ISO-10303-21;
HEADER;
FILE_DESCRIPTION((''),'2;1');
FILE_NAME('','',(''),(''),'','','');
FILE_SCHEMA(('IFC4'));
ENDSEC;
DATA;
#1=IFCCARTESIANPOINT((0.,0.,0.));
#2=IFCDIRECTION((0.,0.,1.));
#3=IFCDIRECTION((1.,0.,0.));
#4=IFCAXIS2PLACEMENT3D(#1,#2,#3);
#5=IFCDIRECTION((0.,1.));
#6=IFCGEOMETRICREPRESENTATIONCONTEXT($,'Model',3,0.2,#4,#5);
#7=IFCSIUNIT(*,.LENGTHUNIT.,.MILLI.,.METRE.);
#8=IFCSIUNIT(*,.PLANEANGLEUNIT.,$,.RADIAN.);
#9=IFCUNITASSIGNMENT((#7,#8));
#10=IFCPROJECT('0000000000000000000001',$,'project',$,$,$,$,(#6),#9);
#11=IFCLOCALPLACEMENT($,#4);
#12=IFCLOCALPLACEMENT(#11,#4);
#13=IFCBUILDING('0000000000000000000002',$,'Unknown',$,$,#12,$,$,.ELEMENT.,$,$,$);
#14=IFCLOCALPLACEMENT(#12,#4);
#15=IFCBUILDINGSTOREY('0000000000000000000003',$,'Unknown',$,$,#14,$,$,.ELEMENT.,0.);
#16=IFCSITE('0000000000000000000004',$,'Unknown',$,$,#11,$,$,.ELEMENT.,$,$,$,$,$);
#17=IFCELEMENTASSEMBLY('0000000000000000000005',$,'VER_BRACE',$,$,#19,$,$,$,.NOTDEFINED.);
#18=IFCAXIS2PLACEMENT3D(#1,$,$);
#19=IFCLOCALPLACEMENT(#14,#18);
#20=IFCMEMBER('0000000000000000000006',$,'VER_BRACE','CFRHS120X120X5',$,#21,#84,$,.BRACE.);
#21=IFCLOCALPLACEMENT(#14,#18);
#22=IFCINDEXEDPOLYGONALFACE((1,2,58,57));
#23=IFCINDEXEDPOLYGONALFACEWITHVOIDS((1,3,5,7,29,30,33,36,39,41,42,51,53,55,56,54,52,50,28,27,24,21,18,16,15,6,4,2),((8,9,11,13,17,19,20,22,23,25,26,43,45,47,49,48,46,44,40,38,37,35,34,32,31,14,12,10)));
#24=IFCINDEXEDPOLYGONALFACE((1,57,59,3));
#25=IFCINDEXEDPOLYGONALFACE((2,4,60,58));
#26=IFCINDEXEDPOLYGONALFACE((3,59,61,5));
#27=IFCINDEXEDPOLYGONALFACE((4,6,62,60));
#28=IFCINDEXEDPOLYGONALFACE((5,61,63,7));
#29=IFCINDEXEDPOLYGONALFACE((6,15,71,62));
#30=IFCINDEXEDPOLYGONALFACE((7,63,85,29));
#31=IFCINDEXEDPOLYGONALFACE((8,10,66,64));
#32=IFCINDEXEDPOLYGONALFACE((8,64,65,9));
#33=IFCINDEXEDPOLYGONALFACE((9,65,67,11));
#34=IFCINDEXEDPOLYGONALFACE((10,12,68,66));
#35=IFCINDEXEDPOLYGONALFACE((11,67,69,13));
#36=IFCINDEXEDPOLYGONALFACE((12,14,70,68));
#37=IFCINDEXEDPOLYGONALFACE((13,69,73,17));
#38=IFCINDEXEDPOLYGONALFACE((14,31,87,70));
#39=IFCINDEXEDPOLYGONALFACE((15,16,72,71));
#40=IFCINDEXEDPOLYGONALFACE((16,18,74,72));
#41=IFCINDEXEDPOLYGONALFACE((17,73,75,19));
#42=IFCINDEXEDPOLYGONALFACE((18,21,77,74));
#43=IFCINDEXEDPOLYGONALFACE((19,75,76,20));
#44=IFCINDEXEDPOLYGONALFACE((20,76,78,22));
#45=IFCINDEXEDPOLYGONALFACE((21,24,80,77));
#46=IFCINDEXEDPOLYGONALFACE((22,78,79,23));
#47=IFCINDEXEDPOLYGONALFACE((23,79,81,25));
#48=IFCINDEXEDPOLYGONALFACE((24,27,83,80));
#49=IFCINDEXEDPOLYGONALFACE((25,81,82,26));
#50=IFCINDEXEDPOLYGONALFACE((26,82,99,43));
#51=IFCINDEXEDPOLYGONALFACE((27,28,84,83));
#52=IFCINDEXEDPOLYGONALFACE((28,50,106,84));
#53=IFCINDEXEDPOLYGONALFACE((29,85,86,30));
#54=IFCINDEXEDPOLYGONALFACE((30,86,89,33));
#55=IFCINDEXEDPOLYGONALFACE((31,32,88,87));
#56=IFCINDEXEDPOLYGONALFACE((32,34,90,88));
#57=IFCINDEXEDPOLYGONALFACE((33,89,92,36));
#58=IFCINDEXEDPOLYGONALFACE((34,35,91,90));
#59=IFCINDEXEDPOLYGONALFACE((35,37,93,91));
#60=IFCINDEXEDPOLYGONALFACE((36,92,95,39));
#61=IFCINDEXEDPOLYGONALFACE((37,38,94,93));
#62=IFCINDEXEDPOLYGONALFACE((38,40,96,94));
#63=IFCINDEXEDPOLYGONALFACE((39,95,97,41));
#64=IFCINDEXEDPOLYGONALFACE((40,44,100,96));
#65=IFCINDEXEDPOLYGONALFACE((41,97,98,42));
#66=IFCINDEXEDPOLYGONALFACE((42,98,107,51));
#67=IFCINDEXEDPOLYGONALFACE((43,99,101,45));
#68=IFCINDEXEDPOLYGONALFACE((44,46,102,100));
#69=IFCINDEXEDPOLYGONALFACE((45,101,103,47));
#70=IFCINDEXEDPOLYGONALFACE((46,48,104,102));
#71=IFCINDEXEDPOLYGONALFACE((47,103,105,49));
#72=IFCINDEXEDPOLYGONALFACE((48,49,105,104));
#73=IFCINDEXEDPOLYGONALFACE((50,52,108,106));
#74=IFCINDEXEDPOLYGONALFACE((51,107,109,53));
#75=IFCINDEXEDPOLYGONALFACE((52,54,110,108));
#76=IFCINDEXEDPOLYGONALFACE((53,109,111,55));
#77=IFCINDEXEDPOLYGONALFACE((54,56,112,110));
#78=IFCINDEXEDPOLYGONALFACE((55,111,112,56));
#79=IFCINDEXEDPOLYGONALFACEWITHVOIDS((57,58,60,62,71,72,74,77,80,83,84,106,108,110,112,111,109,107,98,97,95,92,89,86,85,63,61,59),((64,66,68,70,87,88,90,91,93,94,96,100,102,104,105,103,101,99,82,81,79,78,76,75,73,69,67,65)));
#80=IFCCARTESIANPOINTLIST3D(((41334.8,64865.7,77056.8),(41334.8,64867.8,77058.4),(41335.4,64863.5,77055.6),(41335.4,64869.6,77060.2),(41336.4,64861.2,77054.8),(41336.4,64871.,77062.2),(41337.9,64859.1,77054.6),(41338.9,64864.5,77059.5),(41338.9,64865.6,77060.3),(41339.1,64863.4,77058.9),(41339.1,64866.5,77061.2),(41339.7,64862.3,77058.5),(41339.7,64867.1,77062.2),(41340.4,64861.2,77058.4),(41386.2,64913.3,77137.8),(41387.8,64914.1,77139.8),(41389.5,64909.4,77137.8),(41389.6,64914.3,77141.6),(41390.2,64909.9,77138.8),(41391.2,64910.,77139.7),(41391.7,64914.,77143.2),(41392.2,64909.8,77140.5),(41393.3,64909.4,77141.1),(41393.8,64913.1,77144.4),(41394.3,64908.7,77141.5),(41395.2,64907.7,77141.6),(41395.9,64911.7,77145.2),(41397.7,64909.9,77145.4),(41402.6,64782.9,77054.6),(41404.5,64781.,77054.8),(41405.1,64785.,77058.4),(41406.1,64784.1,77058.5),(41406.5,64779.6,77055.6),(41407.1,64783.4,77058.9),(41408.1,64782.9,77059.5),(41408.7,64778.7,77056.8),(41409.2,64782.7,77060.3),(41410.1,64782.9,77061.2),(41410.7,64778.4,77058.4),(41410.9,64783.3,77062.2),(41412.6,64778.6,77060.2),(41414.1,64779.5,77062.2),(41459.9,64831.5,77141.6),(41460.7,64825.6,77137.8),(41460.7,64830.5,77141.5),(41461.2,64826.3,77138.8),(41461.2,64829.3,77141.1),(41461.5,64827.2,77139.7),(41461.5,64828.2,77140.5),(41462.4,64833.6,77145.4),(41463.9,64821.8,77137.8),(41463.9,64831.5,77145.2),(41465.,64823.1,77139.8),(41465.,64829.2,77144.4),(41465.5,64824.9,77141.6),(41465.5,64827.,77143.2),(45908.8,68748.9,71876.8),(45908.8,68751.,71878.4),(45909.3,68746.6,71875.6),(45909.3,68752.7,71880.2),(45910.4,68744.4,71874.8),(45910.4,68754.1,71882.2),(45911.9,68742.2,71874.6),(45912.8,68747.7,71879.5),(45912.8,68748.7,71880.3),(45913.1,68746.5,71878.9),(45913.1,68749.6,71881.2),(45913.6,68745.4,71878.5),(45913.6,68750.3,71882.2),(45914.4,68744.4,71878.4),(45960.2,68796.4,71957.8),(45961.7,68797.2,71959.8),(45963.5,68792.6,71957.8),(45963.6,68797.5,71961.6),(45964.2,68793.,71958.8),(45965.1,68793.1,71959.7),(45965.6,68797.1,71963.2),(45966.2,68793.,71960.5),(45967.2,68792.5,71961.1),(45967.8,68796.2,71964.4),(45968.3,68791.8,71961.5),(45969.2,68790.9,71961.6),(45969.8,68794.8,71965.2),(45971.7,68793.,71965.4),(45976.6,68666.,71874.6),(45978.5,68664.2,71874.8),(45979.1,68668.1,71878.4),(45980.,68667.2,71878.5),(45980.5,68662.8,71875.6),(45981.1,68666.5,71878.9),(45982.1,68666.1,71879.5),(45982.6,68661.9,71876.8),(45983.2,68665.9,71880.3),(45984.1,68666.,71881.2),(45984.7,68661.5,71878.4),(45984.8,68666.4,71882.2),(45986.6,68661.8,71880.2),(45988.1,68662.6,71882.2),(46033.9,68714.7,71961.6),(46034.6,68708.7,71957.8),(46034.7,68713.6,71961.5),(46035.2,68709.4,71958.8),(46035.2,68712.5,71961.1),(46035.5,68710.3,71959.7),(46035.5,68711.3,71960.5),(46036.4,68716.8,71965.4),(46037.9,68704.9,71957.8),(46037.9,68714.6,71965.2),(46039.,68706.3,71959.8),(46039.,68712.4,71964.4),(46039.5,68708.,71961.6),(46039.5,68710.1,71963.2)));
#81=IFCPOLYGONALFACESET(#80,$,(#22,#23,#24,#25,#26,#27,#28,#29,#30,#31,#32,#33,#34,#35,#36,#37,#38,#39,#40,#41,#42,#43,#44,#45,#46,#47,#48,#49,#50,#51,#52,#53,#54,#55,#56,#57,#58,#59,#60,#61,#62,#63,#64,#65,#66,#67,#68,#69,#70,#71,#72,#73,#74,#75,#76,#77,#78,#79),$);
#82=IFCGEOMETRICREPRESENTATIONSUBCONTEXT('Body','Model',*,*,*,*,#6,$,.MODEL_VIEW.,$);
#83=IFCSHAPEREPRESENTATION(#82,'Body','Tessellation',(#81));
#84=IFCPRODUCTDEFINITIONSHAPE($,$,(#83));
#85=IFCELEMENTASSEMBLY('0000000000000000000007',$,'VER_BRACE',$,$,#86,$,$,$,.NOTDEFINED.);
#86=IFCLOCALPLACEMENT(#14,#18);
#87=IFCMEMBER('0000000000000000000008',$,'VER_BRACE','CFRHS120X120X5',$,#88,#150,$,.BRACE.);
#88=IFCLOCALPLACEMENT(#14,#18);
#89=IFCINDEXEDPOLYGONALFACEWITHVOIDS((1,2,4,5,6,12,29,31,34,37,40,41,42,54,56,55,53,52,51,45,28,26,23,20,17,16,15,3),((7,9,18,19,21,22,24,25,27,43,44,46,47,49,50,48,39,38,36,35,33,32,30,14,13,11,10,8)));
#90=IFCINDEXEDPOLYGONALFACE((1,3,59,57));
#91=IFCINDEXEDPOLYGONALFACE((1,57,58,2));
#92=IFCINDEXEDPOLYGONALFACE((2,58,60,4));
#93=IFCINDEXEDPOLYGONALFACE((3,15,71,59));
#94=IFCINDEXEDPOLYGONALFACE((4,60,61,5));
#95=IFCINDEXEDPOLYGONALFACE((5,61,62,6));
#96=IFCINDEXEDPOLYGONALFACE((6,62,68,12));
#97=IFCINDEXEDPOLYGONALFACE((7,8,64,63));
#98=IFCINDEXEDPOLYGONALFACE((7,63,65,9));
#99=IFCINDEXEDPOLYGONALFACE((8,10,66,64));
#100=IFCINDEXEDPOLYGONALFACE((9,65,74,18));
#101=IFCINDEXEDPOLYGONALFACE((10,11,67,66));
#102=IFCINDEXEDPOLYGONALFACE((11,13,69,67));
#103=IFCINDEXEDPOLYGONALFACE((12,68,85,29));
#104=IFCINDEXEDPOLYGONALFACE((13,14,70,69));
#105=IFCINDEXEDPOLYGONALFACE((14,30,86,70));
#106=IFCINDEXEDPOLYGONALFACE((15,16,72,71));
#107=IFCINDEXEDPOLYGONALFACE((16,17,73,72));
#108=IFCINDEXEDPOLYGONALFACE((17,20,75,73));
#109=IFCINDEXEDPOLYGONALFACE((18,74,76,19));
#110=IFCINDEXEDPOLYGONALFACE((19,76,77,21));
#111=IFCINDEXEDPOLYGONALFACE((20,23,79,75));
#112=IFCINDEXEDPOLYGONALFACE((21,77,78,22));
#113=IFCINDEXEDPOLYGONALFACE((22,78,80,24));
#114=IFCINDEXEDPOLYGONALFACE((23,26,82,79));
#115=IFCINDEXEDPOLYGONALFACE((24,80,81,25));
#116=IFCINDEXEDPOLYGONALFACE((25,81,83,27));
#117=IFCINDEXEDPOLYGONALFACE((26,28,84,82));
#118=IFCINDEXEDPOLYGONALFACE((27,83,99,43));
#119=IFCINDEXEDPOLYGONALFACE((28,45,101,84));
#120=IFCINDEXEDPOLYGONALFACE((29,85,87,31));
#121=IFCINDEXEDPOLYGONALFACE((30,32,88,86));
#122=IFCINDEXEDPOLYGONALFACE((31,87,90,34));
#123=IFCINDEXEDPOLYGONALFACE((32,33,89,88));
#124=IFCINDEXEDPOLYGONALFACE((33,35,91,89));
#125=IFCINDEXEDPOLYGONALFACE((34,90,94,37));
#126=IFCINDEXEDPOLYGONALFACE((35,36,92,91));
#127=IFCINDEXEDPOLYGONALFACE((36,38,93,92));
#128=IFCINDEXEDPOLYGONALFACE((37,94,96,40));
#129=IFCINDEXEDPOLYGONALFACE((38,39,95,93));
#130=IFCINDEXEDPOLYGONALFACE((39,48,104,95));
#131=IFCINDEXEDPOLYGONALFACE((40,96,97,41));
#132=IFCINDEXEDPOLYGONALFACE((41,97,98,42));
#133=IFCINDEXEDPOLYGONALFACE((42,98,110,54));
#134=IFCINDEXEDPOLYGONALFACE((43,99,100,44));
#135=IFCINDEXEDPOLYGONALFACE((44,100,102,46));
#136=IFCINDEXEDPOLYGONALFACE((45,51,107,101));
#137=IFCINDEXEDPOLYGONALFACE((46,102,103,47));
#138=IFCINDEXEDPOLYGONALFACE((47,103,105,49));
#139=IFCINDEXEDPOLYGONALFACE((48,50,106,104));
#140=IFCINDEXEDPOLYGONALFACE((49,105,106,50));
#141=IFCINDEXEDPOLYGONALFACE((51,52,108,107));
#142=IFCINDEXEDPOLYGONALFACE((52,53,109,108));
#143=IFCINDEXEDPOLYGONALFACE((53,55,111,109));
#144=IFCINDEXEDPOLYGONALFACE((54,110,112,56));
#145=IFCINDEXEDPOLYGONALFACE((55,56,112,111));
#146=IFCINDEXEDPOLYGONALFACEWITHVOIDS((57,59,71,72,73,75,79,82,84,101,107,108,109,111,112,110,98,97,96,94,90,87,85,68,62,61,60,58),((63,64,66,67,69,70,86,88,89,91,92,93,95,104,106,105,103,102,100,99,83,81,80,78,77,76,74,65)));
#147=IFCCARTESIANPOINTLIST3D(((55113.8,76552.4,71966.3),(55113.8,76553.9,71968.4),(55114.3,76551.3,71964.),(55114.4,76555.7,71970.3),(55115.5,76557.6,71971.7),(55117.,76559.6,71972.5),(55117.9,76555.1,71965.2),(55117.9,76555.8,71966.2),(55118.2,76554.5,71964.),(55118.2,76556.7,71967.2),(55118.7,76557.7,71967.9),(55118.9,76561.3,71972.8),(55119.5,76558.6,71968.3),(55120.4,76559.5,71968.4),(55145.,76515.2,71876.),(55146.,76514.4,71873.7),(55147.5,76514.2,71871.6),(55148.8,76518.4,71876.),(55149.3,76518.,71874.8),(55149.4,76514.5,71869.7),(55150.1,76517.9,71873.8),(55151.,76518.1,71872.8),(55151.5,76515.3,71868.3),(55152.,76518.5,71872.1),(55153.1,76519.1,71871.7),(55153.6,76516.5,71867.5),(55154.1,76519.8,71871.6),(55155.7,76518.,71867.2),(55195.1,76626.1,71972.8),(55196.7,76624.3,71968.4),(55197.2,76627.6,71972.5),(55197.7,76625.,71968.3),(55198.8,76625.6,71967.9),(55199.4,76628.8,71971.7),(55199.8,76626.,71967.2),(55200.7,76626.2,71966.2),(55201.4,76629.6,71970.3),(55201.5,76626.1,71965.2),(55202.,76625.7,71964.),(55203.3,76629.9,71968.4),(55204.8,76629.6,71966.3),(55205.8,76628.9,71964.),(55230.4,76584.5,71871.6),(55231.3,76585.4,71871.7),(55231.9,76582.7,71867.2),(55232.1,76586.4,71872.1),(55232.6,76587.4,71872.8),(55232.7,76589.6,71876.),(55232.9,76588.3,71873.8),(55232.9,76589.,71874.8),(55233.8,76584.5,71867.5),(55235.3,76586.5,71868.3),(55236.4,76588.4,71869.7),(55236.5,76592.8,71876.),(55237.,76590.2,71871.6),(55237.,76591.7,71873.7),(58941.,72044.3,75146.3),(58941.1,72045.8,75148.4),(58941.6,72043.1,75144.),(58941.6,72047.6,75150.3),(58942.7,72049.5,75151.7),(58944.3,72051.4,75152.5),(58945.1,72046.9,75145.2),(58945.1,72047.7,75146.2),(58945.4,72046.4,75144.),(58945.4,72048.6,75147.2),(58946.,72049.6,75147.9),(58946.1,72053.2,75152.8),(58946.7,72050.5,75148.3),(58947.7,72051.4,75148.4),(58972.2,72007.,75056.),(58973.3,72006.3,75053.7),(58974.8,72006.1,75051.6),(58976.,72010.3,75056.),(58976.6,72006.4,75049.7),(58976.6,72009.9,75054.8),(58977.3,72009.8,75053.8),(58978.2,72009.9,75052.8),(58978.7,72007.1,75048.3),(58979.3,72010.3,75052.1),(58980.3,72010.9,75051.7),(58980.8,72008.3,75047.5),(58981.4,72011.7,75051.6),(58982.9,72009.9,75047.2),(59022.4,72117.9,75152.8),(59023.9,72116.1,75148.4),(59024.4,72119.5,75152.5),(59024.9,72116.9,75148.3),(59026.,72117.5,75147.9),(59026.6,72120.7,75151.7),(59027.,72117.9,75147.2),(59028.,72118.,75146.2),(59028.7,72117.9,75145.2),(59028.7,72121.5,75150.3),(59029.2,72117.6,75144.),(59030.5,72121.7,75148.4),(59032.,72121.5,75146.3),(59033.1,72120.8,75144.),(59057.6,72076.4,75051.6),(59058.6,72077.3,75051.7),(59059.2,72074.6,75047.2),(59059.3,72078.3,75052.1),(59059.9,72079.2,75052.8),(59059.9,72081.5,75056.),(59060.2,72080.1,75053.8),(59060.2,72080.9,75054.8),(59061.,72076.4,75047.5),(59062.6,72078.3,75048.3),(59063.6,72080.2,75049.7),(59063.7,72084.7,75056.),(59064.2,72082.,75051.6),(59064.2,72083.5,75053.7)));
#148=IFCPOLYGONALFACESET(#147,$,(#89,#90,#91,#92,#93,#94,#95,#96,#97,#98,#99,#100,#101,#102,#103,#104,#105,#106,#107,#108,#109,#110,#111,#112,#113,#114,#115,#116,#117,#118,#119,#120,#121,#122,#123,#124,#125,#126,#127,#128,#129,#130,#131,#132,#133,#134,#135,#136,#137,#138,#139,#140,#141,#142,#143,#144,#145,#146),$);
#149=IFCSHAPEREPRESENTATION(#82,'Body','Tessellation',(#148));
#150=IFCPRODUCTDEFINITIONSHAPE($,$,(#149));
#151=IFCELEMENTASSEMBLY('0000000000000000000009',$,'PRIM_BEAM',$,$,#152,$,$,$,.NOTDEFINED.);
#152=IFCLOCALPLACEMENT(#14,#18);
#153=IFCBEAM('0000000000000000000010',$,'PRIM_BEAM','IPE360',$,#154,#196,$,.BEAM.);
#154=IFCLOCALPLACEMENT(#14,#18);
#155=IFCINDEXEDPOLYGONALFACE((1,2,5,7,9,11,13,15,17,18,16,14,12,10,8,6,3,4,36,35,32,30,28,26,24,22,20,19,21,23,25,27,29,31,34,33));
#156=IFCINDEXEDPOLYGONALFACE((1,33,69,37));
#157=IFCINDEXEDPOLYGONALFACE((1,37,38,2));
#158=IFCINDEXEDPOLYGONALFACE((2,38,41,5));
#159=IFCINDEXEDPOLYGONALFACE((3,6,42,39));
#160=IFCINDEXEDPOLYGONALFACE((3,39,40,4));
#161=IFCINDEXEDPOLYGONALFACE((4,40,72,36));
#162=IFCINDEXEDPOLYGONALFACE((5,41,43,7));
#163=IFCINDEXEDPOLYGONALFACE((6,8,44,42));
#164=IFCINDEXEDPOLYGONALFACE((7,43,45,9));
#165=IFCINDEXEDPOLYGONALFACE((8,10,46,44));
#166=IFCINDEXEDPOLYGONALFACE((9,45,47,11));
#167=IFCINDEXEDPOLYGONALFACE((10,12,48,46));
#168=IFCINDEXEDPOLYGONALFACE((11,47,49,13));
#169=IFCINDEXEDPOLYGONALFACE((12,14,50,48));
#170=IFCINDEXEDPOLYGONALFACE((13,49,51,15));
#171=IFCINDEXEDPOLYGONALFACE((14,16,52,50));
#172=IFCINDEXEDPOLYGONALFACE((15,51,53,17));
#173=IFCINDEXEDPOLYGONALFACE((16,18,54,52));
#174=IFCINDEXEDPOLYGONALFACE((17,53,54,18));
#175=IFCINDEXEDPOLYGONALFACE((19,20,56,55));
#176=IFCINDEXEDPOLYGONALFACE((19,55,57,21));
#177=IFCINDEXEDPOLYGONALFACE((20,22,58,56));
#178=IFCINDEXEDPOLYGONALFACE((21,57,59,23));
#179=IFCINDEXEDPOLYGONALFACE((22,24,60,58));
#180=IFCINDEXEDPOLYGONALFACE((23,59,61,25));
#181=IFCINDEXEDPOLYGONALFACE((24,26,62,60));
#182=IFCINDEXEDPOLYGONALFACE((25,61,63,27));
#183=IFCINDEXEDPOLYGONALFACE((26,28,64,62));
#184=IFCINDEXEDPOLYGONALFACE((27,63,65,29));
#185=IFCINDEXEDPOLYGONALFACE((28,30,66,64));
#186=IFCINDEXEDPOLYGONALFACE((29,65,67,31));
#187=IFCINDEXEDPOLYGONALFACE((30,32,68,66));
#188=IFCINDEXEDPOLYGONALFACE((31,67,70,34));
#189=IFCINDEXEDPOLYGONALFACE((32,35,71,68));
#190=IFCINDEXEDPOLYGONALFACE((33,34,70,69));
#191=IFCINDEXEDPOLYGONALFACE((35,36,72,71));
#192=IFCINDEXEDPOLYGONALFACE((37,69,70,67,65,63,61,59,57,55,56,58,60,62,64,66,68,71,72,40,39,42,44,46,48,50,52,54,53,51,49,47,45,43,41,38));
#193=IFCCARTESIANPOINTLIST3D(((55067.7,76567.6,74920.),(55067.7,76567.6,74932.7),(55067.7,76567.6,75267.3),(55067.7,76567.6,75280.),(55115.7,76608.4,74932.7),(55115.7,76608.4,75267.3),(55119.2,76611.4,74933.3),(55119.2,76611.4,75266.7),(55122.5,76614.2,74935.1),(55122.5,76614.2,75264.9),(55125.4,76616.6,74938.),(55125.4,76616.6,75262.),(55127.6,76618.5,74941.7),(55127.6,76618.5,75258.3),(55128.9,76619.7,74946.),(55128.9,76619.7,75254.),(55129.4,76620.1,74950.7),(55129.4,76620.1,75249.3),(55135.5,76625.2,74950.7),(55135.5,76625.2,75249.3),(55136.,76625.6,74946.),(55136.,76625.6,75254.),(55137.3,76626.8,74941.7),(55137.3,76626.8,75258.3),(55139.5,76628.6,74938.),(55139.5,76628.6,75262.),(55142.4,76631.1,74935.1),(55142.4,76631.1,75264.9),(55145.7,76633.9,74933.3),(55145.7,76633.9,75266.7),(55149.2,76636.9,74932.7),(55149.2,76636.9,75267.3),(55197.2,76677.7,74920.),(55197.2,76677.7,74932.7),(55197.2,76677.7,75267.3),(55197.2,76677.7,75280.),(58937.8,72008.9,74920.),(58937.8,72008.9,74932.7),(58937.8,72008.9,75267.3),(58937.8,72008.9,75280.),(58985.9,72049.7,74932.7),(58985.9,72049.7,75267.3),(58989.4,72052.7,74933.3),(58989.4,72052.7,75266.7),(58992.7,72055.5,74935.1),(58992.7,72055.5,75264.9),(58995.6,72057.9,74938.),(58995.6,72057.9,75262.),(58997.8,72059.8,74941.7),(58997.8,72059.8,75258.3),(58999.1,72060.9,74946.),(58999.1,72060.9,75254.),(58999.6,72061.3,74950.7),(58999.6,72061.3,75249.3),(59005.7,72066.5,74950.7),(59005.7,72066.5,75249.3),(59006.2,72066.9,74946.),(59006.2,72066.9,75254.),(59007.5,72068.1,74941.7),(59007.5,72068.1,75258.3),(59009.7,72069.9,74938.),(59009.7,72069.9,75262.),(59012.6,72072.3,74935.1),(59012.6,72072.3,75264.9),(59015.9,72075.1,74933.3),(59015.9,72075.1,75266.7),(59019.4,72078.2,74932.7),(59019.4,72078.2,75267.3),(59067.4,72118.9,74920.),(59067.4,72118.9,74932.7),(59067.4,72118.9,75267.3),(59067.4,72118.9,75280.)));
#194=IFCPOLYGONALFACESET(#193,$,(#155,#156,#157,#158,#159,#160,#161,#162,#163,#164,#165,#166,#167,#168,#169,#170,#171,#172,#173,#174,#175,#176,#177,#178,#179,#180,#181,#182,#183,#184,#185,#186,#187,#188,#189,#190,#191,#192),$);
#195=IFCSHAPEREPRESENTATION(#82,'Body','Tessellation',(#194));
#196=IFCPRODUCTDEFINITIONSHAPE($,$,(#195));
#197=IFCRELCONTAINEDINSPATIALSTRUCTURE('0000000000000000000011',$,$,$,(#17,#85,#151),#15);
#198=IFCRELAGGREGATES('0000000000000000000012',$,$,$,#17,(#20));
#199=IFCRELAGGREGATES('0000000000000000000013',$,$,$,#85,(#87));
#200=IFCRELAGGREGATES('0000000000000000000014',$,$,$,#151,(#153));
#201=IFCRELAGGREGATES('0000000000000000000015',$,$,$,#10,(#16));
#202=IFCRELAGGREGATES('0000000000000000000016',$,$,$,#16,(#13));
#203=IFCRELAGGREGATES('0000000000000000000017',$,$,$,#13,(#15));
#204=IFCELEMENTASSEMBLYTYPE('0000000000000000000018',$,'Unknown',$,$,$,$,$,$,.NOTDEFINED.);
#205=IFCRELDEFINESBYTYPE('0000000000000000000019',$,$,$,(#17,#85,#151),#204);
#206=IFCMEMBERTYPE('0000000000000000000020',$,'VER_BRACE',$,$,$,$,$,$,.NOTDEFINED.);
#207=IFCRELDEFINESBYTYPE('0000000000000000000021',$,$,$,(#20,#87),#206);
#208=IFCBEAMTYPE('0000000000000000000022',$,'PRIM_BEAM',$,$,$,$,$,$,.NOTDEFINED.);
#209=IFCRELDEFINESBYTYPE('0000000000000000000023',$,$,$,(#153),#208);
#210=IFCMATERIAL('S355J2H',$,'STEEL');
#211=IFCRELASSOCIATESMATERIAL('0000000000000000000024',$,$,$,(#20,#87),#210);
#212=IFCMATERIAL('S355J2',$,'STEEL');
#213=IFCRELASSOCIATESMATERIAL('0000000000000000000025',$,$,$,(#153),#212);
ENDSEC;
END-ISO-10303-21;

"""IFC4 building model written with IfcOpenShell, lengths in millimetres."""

from ifc_helpers import new_model, si_unit, direction, frame, origin_with_axes, origin_2d_with_axis, place, context, subcontext, project, spatial, hollow_rectangle, i_section, extrude, material, material_profile, profile_set, profile_usage, type_object, element, aggregate, save


model = new_model("IFC4")

# Units and contexts
model_context = context("Model", 3, precision=0.2, world=origin_with_axes(), true_north=direction((0.0, 1.0)))
body_context = subcontext(model_context, "Body", "Model", "MODEL_VIEW")
ifc_project = project(units=[si_unit("LENGTHUNIT", "METRE", prefix="MILLI"), si_unit("PLANEANGLEUNIT", "RADIAN")], contexts=[model_context])

# Site, building, storey
site_placement = place(None, origin_with_axes())
site = spatial("IfcSite", under=ifc_project, at=site_placement, Name="Unknown", CompositionType="ELEMENT")
building_placement = place(site_placement, origin_with_axes())
building = spatial("IfcBuilding", under=site, at=building_placement, Name="Unknown", CompositionType="ELEMENT")
storey_placement = place(building_placement, origin_with_axes())
storey = spatial("IfcBuildingStorey", under=building, at=storey_placement, Name="Unknown", CompositionType="ELEMENT", Elevation=0.0)

# Shared definitions
element_assembly_type = type_object("IfcElementAssemblyType", Name="Unknown", PredefinedType="NOTDEFINED")
ifc_material_1 = material(Name="S355J2", Category="STEEL")

# Element assemblies, members
assembly_1_placement = place(storey_placement, frame((45974.1, 68729.5, 71920.0), z_axis=(-0.64719, 0.762329, 0.0), x_axis=(-0.577034, -0.489882, 0.653488)))
assembly_1 = element("IfcElementAssembly", 1, at=assembly_1_placement, inside=storey, type_object=element_assembly_type, Name="VER_BRACE", PredefinedType="NOTDEFINED")
ifc_material_2 = material(Name="S355J2H", Category="STEEL")
ifc_material_profile_1 = material_profile(ifc_material_2, hollow_rectangle(XDim=120.0, YDim=120.0, WallThickness=5.0, InnerFilletRadius=5.0, OuterFilletRadius=10.0, at=origin_2d_with_axis()), Name="CFRHS120X120X5")
ifc_profile_set_1 = profile_set([ifc_material_profile_1])
ifc_profile_usage_1 = profile_usage(ifc_profile_set_1, cardinal=5)
member_type = type_object("IfcMemberType", Name="VER_BRACE")
member_1_placement = place(assembly_1_placement, origin_with_axes())
member_1 = element("IfcMember", 2, at=member_1_placement, type_object=member_type, material=ifc_profile_usage_1, Name="VER_BRACE", Description="CFRHS120X120X5", PredefinedType="BRACE", context=body_context, shape_type="SolidModel", body=[
    extrude(hollow_rectangle(XDim=120.0, YDim=120.0, WallThickness=5.0, InnerFilletRadius=5.0, OuterFilletRadius=10.0, at=origin_2d_with_axis()), frame((0.0, 0.0, 0.0), z_axis=(-1.0, 0.0, 0.0), x_axis=(0.0, 0.0, 1.0)), (0.0, 0.0, -1.0), 7926.7),
])
aggregate(assembly_1, [member_1])
assembly_2_placement = place(storey_placement, frame((55175.4, 76572.0, 71920.0), z_axis=(-0.762329, -0.64719, 0.0), x_axis=(0.570003, -0.67141, 0.473608)))
assembly_2 = element("IfcElementAssembly", 3, at=assembly_2_placement, inside=storey, type_object=element_assembly_type, Name="VER_BRACE", PredefinedType="NOTDEFINED")
member_2_placement = place(assembly_2_placement, origin_with_axes())
member_2 = element("IfcMember", 4, at=member_2_placement, type_object=member_type, material=ifc_profile_usage_1, Name="VER_BRACE", Description="CFRHS120X120X5", PredefinedType="BRACE", context=body_context, shape_type="SolidModel", body=[
    extrude(hollow_rectangle(XDim=120.0, YDim=120.0, WallThickness=5.0, InnerFilletRadius=5.0, OuterFilletRadius=10.0, at=origin_2d_with_axis()), frame((0.0, 0.0, 0.0), z_axis=(-1.0, 0.0, 0.0), x_axis=(0.0, 0.0, 1.0)), (0.0, 0.0, -1.0), 6714.4),
])
aggregate(assembly_2, [member_2])

# Element assembly, beam
assembly_3_placement = place(storey_placement, frame((59002.6, 72063.9, 75100.0), z_axis=(0.762329, 0.64719, 0.0), x_axis=(-0.64719, 0.762329, 0.0)))
assembly_3 = element("IfcElementAssembly", 5, at=assembly_3_placement, inside=storey, type_object=element_assembly_type, Name="PRIM_BEAM", PredefinedType="NOTDEFINED")
ifc_material_profile_2 = material_profile(ifc_material_1, i_section(OverallWidth=170.0, OverallDepth=360.0, WebThickness=8.0, FlangeThickness=12.7, FilletRadius=18.0, FlangeEdgeRadius=0.0, FlangeSlope=0.0, at=origin_2d_with_axis()), Name="IPE360")
ifc_profile_set_2 = profile_set([ifc_material_profile_2])
ifc_profile_usage_2 = profile_usage(ifc_profile_set_2, cardinal=2)
beam_type_1 = type_object("IfcBeamType", Name="PRIM_BEAM")
beam_1_placement = place(assembly_3_placement, origin_with_axes())
beam_1 = element("IfcBeam", 6, at=beam_1_placement, type_object=beam_type_1, material=ifc_profile_usage_2, Name="PRIM_BEAM", Description="IPE360", PredefinedType="BEAM", context=body_context, shape_type="SolidModel", body=[
    extrude(i_section(OverallWidth=170.0, OverallDepth=360.0, WebThickness=8.0, FlangeThickness=12.7, FilletRadius=18.0, FlangeEdgeRadius=0.0, FlangeSlope=0.0, at=origin_2d_with_axis()), frame((0.0, 0.0, 0.0), z_axis=(-1.0, 0.0, 0.0), x_axis=(0.0, 0.0, 1.0)), (0.0, 0.0, -1.0), 5980.0),
])
aggregate(assembly_3, [beam_1])

save(model, "model.ifc")
